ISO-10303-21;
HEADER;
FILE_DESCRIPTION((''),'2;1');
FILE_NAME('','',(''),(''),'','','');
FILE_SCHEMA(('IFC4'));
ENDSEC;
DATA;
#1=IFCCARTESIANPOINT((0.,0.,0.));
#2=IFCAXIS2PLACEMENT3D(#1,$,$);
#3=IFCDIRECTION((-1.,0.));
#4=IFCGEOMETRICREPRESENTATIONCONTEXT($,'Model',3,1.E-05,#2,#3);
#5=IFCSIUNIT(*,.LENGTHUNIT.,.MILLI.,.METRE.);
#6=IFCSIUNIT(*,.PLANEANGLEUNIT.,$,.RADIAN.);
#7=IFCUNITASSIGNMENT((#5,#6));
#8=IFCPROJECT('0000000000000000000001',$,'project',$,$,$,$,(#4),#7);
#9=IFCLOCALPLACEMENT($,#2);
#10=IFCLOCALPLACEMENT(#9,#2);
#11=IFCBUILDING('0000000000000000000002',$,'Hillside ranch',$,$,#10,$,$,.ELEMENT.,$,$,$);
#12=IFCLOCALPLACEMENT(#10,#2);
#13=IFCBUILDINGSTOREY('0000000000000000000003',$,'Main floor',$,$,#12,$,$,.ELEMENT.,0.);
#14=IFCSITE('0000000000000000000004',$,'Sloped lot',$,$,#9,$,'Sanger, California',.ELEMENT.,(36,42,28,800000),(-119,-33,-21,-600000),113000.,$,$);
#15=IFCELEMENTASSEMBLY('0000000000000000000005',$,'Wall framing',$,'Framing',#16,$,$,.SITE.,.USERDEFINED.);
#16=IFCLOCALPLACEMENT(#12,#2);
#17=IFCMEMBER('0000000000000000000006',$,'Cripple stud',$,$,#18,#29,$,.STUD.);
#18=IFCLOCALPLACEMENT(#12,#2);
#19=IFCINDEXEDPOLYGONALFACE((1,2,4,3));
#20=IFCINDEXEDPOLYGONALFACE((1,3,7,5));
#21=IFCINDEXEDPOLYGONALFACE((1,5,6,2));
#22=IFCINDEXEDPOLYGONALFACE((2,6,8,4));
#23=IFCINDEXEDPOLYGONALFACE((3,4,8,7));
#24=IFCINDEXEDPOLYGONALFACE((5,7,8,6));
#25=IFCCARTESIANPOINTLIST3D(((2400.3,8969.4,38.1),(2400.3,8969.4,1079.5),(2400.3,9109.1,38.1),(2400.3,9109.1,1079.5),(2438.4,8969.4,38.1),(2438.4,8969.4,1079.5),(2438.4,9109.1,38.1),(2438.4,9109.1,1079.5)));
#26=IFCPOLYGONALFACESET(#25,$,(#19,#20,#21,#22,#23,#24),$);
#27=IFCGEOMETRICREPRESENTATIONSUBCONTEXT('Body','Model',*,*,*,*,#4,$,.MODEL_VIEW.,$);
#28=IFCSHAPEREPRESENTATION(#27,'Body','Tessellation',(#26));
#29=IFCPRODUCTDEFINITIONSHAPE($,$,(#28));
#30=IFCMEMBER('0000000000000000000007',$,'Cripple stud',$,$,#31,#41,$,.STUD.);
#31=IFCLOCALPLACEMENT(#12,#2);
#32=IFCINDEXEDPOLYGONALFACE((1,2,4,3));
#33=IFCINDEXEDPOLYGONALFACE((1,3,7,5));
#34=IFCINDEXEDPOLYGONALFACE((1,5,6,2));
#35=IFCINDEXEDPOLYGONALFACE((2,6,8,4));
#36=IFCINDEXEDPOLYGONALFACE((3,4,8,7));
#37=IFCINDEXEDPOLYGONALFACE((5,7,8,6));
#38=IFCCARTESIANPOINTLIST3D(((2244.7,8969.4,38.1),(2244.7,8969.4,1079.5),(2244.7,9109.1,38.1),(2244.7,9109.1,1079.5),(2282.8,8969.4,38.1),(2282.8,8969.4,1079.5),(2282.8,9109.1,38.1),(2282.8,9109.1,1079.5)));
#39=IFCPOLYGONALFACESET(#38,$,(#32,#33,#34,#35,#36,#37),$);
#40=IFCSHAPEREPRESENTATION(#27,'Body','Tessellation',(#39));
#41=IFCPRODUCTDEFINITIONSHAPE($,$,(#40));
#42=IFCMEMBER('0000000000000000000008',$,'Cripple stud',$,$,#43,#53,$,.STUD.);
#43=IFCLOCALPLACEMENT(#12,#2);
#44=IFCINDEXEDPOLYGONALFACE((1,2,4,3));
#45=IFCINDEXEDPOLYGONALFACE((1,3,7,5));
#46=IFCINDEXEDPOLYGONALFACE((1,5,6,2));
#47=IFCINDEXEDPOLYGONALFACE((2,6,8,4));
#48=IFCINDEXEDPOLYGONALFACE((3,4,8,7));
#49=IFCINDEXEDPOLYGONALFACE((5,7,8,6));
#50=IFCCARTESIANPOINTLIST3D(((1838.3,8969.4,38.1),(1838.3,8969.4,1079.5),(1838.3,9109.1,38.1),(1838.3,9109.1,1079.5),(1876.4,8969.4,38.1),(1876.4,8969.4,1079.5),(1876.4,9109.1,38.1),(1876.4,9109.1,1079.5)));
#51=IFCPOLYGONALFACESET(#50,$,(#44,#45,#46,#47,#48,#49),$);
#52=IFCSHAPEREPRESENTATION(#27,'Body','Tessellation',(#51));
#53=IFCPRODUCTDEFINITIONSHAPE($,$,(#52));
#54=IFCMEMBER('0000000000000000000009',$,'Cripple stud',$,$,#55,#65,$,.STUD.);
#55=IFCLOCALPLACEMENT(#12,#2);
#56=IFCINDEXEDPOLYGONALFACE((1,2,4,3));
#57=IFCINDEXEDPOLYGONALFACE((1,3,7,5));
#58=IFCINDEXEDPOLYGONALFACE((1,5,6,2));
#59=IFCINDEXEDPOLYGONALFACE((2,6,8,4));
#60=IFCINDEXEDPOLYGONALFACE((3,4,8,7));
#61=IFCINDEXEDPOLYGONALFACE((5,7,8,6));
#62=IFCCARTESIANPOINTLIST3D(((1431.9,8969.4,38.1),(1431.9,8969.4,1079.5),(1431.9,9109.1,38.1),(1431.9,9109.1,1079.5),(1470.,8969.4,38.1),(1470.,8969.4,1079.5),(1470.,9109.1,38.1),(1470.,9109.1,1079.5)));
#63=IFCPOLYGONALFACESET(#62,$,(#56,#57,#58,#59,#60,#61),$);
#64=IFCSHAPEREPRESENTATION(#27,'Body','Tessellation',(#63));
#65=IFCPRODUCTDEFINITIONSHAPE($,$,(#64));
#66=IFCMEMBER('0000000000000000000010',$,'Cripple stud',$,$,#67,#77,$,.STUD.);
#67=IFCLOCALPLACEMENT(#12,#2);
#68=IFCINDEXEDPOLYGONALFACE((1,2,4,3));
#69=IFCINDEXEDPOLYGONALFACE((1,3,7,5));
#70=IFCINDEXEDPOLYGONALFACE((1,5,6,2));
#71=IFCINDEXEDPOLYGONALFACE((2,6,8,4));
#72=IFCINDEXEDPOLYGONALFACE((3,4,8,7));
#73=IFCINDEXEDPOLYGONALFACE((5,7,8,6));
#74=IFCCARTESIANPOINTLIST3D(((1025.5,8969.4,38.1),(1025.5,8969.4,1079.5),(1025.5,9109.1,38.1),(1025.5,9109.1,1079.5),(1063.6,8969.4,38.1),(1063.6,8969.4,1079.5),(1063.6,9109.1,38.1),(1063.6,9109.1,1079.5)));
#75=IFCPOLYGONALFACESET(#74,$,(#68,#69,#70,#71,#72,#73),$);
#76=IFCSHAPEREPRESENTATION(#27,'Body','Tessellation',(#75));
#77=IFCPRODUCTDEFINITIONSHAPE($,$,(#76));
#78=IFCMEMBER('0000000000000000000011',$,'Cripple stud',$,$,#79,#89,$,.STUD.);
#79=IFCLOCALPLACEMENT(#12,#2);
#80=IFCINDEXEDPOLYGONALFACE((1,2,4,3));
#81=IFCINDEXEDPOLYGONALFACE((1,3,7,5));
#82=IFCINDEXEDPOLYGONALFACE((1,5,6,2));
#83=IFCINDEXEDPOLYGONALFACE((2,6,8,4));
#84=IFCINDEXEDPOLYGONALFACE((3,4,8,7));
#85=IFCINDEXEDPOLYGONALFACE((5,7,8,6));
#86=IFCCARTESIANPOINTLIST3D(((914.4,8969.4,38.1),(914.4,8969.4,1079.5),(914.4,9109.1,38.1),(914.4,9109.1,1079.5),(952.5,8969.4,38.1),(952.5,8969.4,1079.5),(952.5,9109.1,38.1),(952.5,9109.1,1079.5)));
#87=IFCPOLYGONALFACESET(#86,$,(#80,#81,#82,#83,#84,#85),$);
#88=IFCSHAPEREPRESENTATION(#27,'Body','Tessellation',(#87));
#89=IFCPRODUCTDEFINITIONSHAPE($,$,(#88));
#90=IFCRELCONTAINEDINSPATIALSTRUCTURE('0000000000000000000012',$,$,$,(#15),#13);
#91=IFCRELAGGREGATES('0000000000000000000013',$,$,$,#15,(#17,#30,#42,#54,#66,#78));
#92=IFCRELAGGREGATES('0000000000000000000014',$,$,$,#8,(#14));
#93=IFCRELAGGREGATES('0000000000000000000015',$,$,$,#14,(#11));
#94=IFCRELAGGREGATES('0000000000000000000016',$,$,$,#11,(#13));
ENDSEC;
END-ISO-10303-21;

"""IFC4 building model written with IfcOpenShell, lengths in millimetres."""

from ifc_helpers import new_model, si_unit, direction, frame, origin, origin_with_axes, place, context, subcontext, project, spatial, polyline, outline, extrude, element, aggregate, save


model = new_model("IFC4")

# Units and contexts
model_context = context("Model", 3, precision=1e-05, world=origin(), true_north=direction((-1.0, 0.0)))
body_context = subcontext(model_context, "Body", "Model", "MODEL_VIEW")
ifc_project = project(units=[si_unit("LENGTHUNIT", "METRE", prefix="MILLI"), si_unit("PLANEANGLEUNIT", "RADIAN")], contexts=[model_context])

# Site, building, storey
site_placement = place(None, origin())
site = spatial("IfcSite", under=ifc_project, at=site_placement, Name="Sloped lot", LongName="Sanger, California", CompositionType="ELEMENT", RefLatitude=(36, 42, 28, 800000), RefLongitude=(-119, -33, -21, -600000), RefElevation=113000.0)
building_placement = place(site_placement, origin())
building = spatial("IfcBuilding", under=site, at=building_placement, Name="Hillside ranch", CompositionType="ELEMENT")
storey_placement = place(building_placement, origin())
storey = spatial("IfcBuildingStorey", under=building, at=storey_placement, Name="Main floor", CompositionType="ELEMENT", Elevation=0.0)

# Element assembly, members
assembly_placement = place(storey_placement, origin_with_axes())
assembly = element("IfcElementAssembly", 1, at=assembly_placement, inside=storey, Name="Wall framing", ObjectType="Framing", AssemblyPlace="SITE", PredefinedType="USERDEFINED")
member_1_placement = place(storey_placement, origin_with_axes())
member_1 = element("IfcMember", 2, at=member_1_placement, Name="Cripple stud", PredefinedType="STUD", context=body_context, shape_type="SweptSolid", body=[
    extrude(outline(polyline([(0.0, 0.0), (38.1, 0.0), (38.1, 139.7), (0.0, 139.7), (0.0, 0.0)])), frame((2438.4, 9109.1, 38.1), z_axis=(0.0, 0.0, 1.0), x_axis=(-1.0, 0.0, 0.0)), (0.0, 0.0, 1.0), 1041.4),
])
member_2_placement = place(storey_placement, origin_with_axes())
member_2 = element("IfcMember", 3, at=member_2_placement, Name="Cripple stud", PredefinedType="STUD", context=body_context, shape_type="SweptSolid", body=[
    extrude(outline(polyline([(0.0, 0.0), (38.1, 0.0), (38.1, 139.7), (0.0, 139.7), (0.0, 0.0)])), frame((2282.8, 9109.1, 38.1), z_axis=(0.0, 0.0, 1.0), x_axis=(-1.0, 0.0, 0.0)), (0.0, 0.0, 1.0), 1041.4),
])
member_3_placement = place(storey_placement, origin_with_axes())
member_3 = element("IfcMember", 4, at=member_3_placement, Name="Cripple stud", PredefinedType="STUD", context=body_context, shape_type="SweptSolid", body=[
    extrude(outline(polyline([(0.0, 0.0), (38.1, 0.0), (38.1, 139.7), (0.0, 139.7), (0.0, 0.0)])), frame((1876.4, 9109.1, 38.1), z_axis=(0.0, 0.0, 1.0), x_axis=(-1.0, 0.0, 0.0)), (0.0, 0.0, 1.0), 1041.4),
])
member_4_placement = place(storey_placement, origin_with_axes())
member_4 = element("IfcMember", 5, at=member_4_placement, Name="Cripple stud", PredefinedType="STUD", context=body_context, shape_type="SweptSolid", body=[
    extrude(outline(polyline([(0.0, 0.0), (38.1, 0.0), (38.1, 139.7), (0.0, 139.7), (0.0, 0.0)])), frame((1470.0, 9109.1, 38.1), z_axis=(0.0, 0.0, 1.0), x_axis=(-1.0, 0.0, 0.0)), (0.0, 0.0, 1.0), 1041.4),
])
member_5_placement = place(storey_placement, origin_with_axes())
member_5 = element("IfcMember", 6, at=member_5_placement, Name="Cripple stud", PredefinedType="STUD", context=body_context, shape_type="SweptSolid", body=[
    extrude(outline(polyline([(0.0, 0.0), (38.1, 0.0), (38.1, 139.7), (0.0, 139.7), (0.0, 0.0)])), frame((1063.6, 9109.1, 38.1), z_axis=(0.0, 0.0, 1.0), x_axis=(-1.0, 0.0, 0.0)), (0.0, 0.0, 1.0), 1041.4),
])
member_6_placement = place(storey_placement, origin_with_axes())
member_6 = element("IfcMember", 7, at=member_6_placement, Name="Cripple stud", PredefinedType="STUD", context=body_context, shape_type="SweptSolid", body=[
    extrude(outline(polyline([(0.0, 0.0), (38.1, 0.0), (38.1, 139.7), (0.0, 139.7), (0.0, 0.0)])), frame((952.5, 9109.1, 38.1), z_axis=(0.0, 0.0, 1.0), x_axis=(-1.0, 0.0, 0.0)), (0.0, 0.0, 1.0), 1041.4),
])
aggregate(assembly, [member_1, member_2, member_3, member_4, member_5, member_6])

save(model, "model.ifc")
